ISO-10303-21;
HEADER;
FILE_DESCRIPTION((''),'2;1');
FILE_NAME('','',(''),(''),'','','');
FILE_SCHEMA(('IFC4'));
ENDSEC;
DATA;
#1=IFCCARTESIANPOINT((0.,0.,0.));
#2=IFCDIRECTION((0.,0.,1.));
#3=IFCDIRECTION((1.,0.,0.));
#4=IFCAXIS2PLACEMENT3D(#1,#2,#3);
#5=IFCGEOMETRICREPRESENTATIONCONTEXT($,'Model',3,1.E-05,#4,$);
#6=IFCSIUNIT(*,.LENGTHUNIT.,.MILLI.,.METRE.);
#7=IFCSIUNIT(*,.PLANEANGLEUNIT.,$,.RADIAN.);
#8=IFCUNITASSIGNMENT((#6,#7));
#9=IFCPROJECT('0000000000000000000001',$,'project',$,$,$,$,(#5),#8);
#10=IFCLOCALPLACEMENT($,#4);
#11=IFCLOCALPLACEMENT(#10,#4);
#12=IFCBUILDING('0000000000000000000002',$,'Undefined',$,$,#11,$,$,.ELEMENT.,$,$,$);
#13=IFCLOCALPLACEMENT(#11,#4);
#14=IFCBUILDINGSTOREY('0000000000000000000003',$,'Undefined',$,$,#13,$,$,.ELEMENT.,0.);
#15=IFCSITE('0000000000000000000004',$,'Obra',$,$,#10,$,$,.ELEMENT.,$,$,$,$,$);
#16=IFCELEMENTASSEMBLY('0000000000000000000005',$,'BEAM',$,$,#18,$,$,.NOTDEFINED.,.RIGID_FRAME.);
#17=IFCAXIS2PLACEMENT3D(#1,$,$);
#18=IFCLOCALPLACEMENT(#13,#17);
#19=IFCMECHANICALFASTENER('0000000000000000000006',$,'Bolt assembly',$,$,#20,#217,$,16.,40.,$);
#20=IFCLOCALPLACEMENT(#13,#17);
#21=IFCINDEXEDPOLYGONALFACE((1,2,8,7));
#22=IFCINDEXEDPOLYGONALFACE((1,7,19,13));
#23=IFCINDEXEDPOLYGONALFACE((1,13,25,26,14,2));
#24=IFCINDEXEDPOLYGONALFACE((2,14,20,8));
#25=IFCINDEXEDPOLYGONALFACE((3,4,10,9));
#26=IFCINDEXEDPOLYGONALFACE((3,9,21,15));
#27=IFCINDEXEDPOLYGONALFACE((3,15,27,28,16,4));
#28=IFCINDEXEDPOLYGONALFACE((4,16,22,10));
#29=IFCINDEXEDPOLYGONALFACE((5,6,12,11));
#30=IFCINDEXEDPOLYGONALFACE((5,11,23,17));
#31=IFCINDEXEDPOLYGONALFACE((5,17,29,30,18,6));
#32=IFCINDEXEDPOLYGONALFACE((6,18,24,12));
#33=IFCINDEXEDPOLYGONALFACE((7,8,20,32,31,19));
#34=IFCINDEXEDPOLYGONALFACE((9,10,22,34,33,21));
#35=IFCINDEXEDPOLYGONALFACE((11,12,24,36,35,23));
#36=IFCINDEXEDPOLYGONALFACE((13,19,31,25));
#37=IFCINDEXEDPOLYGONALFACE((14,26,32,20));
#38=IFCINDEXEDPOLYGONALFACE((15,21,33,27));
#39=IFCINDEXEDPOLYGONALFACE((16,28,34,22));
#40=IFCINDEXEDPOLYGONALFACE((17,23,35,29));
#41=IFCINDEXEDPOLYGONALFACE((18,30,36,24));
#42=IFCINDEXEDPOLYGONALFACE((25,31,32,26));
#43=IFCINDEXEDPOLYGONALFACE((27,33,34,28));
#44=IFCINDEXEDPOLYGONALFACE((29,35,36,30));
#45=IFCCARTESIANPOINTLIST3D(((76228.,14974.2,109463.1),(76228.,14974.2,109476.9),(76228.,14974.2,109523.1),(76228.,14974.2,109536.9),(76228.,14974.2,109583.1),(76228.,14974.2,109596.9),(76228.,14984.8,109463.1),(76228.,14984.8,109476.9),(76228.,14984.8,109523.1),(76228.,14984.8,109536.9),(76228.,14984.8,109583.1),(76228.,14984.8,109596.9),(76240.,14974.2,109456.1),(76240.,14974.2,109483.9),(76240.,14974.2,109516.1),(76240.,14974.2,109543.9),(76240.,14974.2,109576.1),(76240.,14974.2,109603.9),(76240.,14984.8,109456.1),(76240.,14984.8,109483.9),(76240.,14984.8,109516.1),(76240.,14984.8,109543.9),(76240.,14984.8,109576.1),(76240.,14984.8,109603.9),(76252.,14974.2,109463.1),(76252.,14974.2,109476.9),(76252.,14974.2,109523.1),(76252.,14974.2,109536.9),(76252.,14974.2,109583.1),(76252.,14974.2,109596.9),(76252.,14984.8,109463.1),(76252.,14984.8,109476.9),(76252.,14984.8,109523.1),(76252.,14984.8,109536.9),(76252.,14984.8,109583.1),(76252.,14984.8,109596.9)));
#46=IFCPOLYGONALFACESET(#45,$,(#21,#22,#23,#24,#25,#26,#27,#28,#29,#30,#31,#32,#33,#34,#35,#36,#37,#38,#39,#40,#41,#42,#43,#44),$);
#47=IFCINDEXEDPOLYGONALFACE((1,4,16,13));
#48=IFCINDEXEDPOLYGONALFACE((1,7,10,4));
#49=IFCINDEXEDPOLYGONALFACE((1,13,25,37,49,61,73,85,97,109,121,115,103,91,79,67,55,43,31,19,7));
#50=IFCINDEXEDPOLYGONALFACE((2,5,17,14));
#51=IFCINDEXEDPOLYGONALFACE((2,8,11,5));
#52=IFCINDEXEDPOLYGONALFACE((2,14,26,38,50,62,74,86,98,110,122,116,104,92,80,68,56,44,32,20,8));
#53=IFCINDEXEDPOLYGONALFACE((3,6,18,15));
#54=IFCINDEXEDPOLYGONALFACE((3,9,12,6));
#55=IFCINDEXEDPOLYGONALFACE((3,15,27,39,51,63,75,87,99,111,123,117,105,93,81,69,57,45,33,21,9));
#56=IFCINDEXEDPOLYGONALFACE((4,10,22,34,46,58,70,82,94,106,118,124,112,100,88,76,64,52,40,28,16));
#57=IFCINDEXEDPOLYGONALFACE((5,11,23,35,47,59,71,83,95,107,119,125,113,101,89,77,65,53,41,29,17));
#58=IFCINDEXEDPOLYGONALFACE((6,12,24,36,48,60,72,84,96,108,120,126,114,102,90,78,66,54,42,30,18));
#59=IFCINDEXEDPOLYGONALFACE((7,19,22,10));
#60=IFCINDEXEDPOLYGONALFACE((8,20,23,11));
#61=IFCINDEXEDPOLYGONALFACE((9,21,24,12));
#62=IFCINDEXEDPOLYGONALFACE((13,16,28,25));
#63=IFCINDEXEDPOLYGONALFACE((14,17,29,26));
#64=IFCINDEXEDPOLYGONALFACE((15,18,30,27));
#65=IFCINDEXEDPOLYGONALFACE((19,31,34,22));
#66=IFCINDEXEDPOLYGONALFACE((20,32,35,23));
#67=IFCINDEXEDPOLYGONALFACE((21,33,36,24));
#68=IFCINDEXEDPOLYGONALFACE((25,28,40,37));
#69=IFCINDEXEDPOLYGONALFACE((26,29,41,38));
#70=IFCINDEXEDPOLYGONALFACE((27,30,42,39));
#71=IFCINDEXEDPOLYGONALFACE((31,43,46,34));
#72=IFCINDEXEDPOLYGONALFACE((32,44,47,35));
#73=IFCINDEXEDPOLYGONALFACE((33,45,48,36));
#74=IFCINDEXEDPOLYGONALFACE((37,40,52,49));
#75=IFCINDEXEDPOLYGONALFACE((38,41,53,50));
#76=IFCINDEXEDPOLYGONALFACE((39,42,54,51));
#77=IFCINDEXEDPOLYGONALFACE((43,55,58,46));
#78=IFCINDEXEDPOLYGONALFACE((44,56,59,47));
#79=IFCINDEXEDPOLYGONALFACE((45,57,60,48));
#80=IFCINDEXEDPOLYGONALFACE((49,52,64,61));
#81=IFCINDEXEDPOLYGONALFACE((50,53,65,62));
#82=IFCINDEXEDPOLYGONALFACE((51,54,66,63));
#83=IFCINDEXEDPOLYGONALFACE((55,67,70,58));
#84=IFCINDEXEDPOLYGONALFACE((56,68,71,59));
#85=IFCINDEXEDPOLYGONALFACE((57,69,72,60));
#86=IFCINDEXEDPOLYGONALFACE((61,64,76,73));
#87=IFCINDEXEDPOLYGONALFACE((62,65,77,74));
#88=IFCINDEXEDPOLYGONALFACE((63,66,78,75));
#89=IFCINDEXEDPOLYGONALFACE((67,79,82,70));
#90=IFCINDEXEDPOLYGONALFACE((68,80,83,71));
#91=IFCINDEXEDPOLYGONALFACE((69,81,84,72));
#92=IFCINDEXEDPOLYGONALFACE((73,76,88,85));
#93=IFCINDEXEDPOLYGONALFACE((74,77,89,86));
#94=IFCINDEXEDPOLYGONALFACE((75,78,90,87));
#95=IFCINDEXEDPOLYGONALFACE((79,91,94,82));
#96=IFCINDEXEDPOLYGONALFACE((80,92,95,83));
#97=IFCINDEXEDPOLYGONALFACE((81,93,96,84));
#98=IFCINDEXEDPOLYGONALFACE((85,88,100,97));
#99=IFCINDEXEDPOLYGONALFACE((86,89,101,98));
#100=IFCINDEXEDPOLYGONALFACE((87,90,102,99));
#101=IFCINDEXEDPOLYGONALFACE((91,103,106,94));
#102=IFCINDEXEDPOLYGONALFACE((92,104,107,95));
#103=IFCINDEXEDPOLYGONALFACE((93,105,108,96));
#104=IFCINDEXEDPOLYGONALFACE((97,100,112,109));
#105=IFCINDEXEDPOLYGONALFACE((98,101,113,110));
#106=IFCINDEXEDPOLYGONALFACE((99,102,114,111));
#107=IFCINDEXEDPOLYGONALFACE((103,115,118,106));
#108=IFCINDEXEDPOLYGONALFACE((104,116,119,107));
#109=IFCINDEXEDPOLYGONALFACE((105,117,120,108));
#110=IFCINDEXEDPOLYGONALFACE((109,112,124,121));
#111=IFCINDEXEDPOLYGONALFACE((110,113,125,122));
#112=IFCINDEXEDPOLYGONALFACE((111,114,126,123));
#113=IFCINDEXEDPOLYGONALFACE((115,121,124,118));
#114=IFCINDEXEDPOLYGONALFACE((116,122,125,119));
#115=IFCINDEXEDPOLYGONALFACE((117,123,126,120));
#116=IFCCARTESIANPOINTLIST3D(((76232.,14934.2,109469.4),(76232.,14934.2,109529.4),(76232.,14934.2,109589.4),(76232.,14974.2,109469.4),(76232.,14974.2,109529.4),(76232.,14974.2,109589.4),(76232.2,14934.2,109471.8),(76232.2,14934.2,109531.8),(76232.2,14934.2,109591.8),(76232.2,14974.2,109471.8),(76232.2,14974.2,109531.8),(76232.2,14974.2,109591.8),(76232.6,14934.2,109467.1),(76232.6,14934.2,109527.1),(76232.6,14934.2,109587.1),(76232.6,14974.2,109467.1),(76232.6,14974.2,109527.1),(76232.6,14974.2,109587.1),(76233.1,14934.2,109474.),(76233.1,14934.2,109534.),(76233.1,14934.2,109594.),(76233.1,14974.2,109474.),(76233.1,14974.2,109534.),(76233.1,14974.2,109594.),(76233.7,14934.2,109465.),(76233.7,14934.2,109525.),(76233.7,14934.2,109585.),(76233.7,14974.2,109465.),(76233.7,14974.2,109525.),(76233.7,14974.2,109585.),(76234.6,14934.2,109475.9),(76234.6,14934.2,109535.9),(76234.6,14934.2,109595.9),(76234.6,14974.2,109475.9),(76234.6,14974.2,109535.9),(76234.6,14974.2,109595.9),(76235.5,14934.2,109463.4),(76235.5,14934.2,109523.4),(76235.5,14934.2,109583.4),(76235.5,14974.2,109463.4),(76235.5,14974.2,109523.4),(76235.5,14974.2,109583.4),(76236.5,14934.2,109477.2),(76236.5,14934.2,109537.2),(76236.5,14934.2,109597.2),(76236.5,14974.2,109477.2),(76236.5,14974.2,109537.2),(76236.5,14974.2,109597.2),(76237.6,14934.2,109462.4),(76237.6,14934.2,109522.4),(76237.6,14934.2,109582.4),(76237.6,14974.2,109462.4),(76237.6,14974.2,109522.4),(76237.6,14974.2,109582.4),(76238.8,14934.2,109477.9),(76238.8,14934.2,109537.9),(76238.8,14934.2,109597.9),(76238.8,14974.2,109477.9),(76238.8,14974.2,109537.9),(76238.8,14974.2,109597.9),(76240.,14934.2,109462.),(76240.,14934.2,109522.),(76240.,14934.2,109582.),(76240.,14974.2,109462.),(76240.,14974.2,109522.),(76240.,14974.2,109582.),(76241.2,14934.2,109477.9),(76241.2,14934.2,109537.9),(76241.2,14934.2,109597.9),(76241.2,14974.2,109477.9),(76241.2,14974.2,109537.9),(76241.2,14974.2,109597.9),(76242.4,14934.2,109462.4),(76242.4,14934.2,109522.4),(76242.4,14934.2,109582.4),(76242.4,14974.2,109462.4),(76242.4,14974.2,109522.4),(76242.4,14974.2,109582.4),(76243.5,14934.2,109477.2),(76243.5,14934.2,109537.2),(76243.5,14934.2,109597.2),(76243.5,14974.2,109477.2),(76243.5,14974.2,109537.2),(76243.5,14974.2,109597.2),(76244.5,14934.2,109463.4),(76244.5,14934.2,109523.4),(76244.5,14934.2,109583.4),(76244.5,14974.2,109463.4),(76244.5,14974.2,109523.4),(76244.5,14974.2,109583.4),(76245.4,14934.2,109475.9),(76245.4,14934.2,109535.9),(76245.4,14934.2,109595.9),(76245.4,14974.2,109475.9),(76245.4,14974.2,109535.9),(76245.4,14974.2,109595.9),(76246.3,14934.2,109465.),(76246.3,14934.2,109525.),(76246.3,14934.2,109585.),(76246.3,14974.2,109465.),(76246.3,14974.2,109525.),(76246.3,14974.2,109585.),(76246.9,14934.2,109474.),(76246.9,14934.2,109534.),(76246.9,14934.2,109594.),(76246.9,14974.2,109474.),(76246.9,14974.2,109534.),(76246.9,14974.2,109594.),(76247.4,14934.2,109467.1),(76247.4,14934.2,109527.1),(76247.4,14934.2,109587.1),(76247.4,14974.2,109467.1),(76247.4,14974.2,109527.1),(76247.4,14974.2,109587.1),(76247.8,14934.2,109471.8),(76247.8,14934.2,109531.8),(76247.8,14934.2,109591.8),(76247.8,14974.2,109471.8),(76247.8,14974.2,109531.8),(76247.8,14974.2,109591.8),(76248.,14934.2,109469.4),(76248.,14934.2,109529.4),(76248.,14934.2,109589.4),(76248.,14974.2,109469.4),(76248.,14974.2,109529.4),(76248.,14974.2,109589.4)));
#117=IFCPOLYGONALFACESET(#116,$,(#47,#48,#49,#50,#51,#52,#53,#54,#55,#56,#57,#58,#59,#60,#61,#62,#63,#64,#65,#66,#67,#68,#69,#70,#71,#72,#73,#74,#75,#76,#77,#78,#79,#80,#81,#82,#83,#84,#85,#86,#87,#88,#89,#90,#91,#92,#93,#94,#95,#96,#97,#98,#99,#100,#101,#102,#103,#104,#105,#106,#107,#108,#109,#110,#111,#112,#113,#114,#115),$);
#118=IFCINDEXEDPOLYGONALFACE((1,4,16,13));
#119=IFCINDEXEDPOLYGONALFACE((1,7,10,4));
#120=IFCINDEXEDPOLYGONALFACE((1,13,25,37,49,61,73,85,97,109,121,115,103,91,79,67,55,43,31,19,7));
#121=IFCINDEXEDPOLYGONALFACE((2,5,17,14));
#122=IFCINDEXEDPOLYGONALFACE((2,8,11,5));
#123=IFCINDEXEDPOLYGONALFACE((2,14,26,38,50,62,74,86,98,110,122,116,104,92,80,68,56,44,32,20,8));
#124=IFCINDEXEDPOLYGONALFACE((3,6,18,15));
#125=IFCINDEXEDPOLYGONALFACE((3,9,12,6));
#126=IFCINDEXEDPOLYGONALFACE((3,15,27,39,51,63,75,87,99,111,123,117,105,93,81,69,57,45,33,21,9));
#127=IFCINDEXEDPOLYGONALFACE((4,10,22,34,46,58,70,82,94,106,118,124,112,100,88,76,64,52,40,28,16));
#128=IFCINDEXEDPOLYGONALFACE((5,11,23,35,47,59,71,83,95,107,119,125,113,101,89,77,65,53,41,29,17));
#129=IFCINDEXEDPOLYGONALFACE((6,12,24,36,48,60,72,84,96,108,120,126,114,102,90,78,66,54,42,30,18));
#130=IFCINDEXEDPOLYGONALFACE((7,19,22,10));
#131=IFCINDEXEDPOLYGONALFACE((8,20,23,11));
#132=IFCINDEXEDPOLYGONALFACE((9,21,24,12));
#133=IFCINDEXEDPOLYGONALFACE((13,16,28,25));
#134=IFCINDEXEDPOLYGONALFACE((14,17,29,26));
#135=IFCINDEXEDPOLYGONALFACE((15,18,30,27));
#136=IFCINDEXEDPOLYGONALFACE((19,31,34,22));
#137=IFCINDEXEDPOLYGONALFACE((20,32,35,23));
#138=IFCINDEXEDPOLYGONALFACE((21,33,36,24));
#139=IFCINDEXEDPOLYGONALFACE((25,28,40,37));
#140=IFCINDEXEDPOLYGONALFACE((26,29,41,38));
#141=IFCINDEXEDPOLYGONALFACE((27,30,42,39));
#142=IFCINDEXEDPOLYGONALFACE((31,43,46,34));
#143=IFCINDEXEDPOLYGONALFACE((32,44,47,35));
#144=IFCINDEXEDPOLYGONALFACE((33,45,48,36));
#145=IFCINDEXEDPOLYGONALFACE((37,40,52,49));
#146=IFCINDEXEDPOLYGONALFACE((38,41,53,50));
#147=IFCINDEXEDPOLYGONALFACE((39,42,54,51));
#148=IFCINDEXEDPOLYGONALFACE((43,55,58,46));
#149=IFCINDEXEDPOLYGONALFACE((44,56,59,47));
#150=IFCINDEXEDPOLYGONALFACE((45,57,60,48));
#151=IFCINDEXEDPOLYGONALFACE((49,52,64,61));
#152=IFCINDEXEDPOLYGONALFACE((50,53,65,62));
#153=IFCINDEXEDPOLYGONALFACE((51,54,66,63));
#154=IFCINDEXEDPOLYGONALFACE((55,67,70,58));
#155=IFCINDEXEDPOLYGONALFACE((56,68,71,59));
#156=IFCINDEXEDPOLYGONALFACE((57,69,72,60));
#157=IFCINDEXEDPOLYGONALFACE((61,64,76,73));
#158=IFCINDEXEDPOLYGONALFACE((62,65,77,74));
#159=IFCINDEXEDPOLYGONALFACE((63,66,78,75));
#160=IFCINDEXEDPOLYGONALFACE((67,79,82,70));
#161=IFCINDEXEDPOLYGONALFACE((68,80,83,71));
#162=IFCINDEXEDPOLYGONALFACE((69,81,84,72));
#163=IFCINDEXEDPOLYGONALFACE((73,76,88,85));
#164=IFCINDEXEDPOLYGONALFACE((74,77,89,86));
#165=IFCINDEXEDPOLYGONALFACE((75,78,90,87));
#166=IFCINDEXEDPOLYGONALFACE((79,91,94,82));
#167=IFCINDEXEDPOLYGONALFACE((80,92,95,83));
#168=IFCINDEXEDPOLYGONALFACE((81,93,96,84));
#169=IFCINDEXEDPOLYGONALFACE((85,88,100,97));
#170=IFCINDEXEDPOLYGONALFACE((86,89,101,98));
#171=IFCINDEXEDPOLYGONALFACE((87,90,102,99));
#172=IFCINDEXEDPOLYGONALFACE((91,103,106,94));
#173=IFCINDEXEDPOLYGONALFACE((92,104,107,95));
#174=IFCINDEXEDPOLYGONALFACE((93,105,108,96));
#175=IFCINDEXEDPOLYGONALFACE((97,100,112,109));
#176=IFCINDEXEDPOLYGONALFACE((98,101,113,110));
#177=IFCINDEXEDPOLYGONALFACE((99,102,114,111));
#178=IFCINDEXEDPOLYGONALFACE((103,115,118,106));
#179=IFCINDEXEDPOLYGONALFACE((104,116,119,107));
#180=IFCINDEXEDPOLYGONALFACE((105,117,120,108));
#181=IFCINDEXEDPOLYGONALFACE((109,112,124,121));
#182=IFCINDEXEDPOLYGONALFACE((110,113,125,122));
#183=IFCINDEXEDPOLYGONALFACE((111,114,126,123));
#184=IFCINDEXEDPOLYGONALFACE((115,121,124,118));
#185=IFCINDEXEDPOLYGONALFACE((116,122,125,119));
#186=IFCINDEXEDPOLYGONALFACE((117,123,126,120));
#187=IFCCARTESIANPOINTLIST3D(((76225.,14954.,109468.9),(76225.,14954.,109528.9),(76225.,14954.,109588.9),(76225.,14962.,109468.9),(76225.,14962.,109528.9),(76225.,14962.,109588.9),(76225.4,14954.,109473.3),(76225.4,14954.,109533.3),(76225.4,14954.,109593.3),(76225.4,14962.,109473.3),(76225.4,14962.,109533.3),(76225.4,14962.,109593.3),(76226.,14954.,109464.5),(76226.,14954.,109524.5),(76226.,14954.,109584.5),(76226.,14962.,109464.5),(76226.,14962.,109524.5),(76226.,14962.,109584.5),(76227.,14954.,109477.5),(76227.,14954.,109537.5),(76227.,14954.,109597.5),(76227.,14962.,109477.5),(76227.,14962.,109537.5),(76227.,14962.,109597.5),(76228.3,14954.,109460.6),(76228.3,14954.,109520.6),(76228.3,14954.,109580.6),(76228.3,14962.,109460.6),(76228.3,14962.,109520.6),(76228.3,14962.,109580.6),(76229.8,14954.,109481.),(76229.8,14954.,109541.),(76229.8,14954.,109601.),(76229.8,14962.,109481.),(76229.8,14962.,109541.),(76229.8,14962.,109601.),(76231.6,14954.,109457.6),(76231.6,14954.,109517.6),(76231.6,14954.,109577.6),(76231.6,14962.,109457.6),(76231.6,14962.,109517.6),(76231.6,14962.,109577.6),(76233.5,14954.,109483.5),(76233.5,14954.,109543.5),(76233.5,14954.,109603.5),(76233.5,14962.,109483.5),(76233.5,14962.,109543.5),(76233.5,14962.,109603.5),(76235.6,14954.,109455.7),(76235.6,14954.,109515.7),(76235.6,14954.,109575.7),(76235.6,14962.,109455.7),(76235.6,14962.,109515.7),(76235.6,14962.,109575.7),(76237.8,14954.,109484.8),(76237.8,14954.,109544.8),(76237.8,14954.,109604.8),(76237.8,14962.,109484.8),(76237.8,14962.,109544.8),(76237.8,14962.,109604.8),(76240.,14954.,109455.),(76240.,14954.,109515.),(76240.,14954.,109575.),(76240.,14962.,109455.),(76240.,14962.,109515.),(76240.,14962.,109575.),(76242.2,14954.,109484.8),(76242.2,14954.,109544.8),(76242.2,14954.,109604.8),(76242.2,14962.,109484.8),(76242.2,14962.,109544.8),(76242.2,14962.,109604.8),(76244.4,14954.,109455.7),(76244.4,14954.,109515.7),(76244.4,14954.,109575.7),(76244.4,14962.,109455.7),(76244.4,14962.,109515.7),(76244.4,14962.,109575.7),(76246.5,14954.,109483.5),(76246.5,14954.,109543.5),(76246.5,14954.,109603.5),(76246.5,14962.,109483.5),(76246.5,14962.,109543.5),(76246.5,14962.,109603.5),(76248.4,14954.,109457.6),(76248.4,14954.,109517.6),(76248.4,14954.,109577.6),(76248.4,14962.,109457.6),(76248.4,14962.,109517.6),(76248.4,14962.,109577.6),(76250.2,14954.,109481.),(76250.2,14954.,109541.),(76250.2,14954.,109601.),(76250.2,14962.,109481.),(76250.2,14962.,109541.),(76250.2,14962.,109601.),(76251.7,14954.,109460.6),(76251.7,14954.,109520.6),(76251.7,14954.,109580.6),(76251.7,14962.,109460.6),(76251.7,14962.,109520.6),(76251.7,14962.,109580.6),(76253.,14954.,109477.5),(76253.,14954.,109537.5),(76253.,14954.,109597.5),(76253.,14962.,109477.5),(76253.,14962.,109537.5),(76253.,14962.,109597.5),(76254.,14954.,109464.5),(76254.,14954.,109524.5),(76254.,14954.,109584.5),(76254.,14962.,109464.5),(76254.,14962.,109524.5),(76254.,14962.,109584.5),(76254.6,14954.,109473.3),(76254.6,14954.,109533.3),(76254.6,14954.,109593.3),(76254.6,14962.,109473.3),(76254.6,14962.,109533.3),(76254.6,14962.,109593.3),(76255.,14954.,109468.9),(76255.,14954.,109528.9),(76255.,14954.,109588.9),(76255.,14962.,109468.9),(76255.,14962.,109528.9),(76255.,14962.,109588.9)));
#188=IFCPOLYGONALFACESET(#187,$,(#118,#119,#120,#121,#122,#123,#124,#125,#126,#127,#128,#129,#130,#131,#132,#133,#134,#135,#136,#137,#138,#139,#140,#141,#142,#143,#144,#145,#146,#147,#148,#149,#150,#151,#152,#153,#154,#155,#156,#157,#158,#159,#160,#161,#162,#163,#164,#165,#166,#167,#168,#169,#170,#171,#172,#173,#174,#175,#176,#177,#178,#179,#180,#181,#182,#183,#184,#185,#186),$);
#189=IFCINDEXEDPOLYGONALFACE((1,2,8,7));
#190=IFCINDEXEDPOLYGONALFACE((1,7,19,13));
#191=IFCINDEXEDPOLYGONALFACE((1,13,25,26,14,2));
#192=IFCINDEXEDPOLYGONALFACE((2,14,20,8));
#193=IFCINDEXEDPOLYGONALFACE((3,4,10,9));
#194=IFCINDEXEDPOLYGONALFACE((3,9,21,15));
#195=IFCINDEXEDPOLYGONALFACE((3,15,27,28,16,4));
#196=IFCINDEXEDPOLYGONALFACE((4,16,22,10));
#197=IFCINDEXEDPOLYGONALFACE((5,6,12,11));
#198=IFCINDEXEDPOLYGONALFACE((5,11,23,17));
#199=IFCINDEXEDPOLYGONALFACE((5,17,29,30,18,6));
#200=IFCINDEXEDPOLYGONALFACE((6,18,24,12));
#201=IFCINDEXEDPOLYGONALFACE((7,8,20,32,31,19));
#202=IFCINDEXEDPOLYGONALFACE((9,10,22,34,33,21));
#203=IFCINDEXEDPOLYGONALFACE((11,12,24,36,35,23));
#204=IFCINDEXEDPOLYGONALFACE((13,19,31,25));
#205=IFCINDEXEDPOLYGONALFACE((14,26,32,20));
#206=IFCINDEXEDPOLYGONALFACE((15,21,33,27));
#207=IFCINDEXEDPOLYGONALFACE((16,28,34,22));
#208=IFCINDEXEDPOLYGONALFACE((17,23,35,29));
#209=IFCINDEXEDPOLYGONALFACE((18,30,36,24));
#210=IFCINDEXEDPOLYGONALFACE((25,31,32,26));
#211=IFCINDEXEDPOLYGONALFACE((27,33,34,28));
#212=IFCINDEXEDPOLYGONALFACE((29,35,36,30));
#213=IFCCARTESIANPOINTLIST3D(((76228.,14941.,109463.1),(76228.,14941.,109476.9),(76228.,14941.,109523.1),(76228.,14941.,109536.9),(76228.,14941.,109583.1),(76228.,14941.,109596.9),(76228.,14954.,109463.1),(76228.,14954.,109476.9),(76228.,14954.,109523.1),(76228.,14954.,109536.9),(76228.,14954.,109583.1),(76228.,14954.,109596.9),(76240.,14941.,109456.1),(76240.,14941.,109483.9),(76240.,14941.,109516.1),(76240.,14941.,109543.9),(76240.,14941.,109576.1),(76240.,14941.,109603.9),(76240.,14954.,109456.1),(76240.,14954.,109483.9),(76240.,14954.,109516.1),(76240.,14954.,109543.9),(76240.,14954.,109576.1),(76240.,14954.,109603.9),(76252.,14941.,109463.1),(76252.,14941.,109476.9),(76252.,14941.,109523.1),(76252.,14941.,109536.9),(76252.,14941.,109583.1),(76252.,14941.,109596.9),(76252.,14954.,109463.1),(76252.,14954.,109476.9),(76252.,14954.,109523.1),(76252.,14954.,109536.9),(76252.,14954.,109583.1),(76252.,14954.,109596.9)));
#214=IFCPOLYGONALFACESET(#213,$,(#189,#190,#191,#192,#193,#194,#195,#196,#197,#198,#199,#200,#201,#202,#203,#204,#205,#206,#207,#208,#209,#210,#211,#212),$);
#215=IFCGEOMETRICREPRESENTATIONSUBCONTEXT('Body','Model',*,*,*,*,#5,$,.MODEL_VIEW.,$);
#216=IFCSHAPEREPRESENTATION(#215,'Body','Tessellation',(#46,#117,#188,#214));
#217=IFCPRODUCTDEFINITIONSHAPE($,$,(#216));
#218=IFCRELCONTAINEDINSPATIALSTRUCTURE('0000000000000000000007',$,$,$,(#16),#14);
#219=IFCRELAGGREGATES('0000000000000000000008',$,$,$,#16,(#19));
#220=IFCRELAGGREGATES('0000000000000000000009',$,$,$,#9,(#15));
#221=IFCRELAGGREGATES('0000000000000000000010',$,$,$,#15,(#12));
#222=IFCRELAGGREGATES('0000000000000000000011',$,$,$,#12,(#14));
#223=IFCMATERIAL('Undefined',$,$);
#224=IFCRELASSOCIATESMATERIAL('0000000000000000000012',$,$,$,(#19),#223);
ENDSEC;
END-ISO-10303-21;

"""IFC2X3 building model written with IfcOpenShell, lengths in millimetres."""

from ifc_helpers import new_model, si_unit, frame, origin_with_axes, origin_2d_with_axis, place, context, subcontext, project, spatial, polyline, circle, outline, extrude, source, transform, mapped, material, element, aggregate, save


model = new_model("IFC2X3")

# Units and contexts
model_context = context("Model", 3, precision=1e-05, world=origin_with_axes())
body_context = subcontext(model_context, "Body", "Model", "MODEL_VIEW")
ifc_project = project(units=[si_unit("LENGTHUNIT", "METRE", prefix="MILLI"), si_unit("PLANEANGLEUNIT", "RADIAN")], contexts=[model_context])

# Site, building, storey
site_placement = place(None, origin_with_axes())
site = spatial("IfcSite", under=ifc_project, at=site_placement, Name="Obra", CompositionType="ELEMENT")
building_placement = place(site_placement, origin_with_axes())
building = spatial("IfcBuilding", under=site, at=building_placement, Name="Undefined", CompositionType="ELEMENT")
storey_placement = place(building_placement, origin_with_axes())
storey = spatial("IfcBuildingStorey", under=building, at=storey_placement, Name="Undefined", CompositionType="ELEMENT", Elevation=0.0)

# Element assembly
assembly_1_placement = place(storey_placement, origin_with_axes())
assembly_1 = element("IfcElementAssembly", 1, at=assembly_1_placement, inside=storey, Name="BEAM", AssemblyPlace="NOTDEFINED", PredefinedType="RIGID_FRAME")

# Mechanical fastener
ifc_material_1 = material(Name="Undefined")
shared_shape_1 = source(origin_with_axes(), body_context, "Body", "SweptSolid", [
    extrude(outline(polyline([(13.9, 0.0), (6.9, 12.0), (-6.9, 12.0), (-13.9, 0.0), (-6.9, -12.0), (6.9, -12.0), (13.9, 0.0)])), frame((0.0, -19.7, 0.0), z_axis=(0.0, 1.0, 0.0), x_axis=(1.0, 0.0, 0.0)), (0.0, 0.0, 1.0), 10.6),
    extrude(circle(Radius=8.0, at=origin_2d_with_axis()), frame((0.0, -9.1, 0.0), z_axis=(0.0, 1.0, 0.0), x_axis=(1.0, 0.0, 0.0)), (0.0, 0.0, 1.0), 40.0),
    extrude(circle(Radius=15.0, at=origin_2d_with_axis()), frame((0.0, 3.1, 0.0), z_axis=(0.0, 1.0, 0.0), x_axis=(1.0, 0.0, 0.0)), (0.0, 0.0, 1.0), 8.0),
    extrude(outline(polyline([(13.9, 0.0), (6.9, 12.0), (-6.9, 12.0), (-13.9, 0.0), (-6.9, -12.0), (6.9, -12.0), (13.9, 0.0)])), frame((0.0, 11.1, 0.0), z_axis=(0.0, 1.0, 0.0), x_axis=(1.0, 0.0, 0.0)), (0.0, 0.0, 1.0), 13.0),
])
mechanical_fastener_1_placement = place(assembly_1_placement, frame((76290.0, 14965.1, 109650.0), z_axis=(-1.0, 0.0, 0.0), x_axis=(0.0, 0.0, -1.0)))
mechanical_fastener_1 = element("IfcMechanicalFastener", 2, at=mechanical_fastener_1_placement, material=ifc_material_1, Name="Bolt assembly", NominalDiameter=16.0, NominalLength=40.0, context=body_context, shape_type="MappedRepresentation", body=[
    mapped(shared_shape_1, transform((60.0, 0.0, 50.0))),
    mapped(shared_shape_1, transform((120.0, 0.0, 50.0))),
    mapped(shared_shape_1, transform((180.0, 0.0, 50.0))),
])
aggregate(assembly_1, [mechanical_fastener_1])

save(model, "model.ifc")
